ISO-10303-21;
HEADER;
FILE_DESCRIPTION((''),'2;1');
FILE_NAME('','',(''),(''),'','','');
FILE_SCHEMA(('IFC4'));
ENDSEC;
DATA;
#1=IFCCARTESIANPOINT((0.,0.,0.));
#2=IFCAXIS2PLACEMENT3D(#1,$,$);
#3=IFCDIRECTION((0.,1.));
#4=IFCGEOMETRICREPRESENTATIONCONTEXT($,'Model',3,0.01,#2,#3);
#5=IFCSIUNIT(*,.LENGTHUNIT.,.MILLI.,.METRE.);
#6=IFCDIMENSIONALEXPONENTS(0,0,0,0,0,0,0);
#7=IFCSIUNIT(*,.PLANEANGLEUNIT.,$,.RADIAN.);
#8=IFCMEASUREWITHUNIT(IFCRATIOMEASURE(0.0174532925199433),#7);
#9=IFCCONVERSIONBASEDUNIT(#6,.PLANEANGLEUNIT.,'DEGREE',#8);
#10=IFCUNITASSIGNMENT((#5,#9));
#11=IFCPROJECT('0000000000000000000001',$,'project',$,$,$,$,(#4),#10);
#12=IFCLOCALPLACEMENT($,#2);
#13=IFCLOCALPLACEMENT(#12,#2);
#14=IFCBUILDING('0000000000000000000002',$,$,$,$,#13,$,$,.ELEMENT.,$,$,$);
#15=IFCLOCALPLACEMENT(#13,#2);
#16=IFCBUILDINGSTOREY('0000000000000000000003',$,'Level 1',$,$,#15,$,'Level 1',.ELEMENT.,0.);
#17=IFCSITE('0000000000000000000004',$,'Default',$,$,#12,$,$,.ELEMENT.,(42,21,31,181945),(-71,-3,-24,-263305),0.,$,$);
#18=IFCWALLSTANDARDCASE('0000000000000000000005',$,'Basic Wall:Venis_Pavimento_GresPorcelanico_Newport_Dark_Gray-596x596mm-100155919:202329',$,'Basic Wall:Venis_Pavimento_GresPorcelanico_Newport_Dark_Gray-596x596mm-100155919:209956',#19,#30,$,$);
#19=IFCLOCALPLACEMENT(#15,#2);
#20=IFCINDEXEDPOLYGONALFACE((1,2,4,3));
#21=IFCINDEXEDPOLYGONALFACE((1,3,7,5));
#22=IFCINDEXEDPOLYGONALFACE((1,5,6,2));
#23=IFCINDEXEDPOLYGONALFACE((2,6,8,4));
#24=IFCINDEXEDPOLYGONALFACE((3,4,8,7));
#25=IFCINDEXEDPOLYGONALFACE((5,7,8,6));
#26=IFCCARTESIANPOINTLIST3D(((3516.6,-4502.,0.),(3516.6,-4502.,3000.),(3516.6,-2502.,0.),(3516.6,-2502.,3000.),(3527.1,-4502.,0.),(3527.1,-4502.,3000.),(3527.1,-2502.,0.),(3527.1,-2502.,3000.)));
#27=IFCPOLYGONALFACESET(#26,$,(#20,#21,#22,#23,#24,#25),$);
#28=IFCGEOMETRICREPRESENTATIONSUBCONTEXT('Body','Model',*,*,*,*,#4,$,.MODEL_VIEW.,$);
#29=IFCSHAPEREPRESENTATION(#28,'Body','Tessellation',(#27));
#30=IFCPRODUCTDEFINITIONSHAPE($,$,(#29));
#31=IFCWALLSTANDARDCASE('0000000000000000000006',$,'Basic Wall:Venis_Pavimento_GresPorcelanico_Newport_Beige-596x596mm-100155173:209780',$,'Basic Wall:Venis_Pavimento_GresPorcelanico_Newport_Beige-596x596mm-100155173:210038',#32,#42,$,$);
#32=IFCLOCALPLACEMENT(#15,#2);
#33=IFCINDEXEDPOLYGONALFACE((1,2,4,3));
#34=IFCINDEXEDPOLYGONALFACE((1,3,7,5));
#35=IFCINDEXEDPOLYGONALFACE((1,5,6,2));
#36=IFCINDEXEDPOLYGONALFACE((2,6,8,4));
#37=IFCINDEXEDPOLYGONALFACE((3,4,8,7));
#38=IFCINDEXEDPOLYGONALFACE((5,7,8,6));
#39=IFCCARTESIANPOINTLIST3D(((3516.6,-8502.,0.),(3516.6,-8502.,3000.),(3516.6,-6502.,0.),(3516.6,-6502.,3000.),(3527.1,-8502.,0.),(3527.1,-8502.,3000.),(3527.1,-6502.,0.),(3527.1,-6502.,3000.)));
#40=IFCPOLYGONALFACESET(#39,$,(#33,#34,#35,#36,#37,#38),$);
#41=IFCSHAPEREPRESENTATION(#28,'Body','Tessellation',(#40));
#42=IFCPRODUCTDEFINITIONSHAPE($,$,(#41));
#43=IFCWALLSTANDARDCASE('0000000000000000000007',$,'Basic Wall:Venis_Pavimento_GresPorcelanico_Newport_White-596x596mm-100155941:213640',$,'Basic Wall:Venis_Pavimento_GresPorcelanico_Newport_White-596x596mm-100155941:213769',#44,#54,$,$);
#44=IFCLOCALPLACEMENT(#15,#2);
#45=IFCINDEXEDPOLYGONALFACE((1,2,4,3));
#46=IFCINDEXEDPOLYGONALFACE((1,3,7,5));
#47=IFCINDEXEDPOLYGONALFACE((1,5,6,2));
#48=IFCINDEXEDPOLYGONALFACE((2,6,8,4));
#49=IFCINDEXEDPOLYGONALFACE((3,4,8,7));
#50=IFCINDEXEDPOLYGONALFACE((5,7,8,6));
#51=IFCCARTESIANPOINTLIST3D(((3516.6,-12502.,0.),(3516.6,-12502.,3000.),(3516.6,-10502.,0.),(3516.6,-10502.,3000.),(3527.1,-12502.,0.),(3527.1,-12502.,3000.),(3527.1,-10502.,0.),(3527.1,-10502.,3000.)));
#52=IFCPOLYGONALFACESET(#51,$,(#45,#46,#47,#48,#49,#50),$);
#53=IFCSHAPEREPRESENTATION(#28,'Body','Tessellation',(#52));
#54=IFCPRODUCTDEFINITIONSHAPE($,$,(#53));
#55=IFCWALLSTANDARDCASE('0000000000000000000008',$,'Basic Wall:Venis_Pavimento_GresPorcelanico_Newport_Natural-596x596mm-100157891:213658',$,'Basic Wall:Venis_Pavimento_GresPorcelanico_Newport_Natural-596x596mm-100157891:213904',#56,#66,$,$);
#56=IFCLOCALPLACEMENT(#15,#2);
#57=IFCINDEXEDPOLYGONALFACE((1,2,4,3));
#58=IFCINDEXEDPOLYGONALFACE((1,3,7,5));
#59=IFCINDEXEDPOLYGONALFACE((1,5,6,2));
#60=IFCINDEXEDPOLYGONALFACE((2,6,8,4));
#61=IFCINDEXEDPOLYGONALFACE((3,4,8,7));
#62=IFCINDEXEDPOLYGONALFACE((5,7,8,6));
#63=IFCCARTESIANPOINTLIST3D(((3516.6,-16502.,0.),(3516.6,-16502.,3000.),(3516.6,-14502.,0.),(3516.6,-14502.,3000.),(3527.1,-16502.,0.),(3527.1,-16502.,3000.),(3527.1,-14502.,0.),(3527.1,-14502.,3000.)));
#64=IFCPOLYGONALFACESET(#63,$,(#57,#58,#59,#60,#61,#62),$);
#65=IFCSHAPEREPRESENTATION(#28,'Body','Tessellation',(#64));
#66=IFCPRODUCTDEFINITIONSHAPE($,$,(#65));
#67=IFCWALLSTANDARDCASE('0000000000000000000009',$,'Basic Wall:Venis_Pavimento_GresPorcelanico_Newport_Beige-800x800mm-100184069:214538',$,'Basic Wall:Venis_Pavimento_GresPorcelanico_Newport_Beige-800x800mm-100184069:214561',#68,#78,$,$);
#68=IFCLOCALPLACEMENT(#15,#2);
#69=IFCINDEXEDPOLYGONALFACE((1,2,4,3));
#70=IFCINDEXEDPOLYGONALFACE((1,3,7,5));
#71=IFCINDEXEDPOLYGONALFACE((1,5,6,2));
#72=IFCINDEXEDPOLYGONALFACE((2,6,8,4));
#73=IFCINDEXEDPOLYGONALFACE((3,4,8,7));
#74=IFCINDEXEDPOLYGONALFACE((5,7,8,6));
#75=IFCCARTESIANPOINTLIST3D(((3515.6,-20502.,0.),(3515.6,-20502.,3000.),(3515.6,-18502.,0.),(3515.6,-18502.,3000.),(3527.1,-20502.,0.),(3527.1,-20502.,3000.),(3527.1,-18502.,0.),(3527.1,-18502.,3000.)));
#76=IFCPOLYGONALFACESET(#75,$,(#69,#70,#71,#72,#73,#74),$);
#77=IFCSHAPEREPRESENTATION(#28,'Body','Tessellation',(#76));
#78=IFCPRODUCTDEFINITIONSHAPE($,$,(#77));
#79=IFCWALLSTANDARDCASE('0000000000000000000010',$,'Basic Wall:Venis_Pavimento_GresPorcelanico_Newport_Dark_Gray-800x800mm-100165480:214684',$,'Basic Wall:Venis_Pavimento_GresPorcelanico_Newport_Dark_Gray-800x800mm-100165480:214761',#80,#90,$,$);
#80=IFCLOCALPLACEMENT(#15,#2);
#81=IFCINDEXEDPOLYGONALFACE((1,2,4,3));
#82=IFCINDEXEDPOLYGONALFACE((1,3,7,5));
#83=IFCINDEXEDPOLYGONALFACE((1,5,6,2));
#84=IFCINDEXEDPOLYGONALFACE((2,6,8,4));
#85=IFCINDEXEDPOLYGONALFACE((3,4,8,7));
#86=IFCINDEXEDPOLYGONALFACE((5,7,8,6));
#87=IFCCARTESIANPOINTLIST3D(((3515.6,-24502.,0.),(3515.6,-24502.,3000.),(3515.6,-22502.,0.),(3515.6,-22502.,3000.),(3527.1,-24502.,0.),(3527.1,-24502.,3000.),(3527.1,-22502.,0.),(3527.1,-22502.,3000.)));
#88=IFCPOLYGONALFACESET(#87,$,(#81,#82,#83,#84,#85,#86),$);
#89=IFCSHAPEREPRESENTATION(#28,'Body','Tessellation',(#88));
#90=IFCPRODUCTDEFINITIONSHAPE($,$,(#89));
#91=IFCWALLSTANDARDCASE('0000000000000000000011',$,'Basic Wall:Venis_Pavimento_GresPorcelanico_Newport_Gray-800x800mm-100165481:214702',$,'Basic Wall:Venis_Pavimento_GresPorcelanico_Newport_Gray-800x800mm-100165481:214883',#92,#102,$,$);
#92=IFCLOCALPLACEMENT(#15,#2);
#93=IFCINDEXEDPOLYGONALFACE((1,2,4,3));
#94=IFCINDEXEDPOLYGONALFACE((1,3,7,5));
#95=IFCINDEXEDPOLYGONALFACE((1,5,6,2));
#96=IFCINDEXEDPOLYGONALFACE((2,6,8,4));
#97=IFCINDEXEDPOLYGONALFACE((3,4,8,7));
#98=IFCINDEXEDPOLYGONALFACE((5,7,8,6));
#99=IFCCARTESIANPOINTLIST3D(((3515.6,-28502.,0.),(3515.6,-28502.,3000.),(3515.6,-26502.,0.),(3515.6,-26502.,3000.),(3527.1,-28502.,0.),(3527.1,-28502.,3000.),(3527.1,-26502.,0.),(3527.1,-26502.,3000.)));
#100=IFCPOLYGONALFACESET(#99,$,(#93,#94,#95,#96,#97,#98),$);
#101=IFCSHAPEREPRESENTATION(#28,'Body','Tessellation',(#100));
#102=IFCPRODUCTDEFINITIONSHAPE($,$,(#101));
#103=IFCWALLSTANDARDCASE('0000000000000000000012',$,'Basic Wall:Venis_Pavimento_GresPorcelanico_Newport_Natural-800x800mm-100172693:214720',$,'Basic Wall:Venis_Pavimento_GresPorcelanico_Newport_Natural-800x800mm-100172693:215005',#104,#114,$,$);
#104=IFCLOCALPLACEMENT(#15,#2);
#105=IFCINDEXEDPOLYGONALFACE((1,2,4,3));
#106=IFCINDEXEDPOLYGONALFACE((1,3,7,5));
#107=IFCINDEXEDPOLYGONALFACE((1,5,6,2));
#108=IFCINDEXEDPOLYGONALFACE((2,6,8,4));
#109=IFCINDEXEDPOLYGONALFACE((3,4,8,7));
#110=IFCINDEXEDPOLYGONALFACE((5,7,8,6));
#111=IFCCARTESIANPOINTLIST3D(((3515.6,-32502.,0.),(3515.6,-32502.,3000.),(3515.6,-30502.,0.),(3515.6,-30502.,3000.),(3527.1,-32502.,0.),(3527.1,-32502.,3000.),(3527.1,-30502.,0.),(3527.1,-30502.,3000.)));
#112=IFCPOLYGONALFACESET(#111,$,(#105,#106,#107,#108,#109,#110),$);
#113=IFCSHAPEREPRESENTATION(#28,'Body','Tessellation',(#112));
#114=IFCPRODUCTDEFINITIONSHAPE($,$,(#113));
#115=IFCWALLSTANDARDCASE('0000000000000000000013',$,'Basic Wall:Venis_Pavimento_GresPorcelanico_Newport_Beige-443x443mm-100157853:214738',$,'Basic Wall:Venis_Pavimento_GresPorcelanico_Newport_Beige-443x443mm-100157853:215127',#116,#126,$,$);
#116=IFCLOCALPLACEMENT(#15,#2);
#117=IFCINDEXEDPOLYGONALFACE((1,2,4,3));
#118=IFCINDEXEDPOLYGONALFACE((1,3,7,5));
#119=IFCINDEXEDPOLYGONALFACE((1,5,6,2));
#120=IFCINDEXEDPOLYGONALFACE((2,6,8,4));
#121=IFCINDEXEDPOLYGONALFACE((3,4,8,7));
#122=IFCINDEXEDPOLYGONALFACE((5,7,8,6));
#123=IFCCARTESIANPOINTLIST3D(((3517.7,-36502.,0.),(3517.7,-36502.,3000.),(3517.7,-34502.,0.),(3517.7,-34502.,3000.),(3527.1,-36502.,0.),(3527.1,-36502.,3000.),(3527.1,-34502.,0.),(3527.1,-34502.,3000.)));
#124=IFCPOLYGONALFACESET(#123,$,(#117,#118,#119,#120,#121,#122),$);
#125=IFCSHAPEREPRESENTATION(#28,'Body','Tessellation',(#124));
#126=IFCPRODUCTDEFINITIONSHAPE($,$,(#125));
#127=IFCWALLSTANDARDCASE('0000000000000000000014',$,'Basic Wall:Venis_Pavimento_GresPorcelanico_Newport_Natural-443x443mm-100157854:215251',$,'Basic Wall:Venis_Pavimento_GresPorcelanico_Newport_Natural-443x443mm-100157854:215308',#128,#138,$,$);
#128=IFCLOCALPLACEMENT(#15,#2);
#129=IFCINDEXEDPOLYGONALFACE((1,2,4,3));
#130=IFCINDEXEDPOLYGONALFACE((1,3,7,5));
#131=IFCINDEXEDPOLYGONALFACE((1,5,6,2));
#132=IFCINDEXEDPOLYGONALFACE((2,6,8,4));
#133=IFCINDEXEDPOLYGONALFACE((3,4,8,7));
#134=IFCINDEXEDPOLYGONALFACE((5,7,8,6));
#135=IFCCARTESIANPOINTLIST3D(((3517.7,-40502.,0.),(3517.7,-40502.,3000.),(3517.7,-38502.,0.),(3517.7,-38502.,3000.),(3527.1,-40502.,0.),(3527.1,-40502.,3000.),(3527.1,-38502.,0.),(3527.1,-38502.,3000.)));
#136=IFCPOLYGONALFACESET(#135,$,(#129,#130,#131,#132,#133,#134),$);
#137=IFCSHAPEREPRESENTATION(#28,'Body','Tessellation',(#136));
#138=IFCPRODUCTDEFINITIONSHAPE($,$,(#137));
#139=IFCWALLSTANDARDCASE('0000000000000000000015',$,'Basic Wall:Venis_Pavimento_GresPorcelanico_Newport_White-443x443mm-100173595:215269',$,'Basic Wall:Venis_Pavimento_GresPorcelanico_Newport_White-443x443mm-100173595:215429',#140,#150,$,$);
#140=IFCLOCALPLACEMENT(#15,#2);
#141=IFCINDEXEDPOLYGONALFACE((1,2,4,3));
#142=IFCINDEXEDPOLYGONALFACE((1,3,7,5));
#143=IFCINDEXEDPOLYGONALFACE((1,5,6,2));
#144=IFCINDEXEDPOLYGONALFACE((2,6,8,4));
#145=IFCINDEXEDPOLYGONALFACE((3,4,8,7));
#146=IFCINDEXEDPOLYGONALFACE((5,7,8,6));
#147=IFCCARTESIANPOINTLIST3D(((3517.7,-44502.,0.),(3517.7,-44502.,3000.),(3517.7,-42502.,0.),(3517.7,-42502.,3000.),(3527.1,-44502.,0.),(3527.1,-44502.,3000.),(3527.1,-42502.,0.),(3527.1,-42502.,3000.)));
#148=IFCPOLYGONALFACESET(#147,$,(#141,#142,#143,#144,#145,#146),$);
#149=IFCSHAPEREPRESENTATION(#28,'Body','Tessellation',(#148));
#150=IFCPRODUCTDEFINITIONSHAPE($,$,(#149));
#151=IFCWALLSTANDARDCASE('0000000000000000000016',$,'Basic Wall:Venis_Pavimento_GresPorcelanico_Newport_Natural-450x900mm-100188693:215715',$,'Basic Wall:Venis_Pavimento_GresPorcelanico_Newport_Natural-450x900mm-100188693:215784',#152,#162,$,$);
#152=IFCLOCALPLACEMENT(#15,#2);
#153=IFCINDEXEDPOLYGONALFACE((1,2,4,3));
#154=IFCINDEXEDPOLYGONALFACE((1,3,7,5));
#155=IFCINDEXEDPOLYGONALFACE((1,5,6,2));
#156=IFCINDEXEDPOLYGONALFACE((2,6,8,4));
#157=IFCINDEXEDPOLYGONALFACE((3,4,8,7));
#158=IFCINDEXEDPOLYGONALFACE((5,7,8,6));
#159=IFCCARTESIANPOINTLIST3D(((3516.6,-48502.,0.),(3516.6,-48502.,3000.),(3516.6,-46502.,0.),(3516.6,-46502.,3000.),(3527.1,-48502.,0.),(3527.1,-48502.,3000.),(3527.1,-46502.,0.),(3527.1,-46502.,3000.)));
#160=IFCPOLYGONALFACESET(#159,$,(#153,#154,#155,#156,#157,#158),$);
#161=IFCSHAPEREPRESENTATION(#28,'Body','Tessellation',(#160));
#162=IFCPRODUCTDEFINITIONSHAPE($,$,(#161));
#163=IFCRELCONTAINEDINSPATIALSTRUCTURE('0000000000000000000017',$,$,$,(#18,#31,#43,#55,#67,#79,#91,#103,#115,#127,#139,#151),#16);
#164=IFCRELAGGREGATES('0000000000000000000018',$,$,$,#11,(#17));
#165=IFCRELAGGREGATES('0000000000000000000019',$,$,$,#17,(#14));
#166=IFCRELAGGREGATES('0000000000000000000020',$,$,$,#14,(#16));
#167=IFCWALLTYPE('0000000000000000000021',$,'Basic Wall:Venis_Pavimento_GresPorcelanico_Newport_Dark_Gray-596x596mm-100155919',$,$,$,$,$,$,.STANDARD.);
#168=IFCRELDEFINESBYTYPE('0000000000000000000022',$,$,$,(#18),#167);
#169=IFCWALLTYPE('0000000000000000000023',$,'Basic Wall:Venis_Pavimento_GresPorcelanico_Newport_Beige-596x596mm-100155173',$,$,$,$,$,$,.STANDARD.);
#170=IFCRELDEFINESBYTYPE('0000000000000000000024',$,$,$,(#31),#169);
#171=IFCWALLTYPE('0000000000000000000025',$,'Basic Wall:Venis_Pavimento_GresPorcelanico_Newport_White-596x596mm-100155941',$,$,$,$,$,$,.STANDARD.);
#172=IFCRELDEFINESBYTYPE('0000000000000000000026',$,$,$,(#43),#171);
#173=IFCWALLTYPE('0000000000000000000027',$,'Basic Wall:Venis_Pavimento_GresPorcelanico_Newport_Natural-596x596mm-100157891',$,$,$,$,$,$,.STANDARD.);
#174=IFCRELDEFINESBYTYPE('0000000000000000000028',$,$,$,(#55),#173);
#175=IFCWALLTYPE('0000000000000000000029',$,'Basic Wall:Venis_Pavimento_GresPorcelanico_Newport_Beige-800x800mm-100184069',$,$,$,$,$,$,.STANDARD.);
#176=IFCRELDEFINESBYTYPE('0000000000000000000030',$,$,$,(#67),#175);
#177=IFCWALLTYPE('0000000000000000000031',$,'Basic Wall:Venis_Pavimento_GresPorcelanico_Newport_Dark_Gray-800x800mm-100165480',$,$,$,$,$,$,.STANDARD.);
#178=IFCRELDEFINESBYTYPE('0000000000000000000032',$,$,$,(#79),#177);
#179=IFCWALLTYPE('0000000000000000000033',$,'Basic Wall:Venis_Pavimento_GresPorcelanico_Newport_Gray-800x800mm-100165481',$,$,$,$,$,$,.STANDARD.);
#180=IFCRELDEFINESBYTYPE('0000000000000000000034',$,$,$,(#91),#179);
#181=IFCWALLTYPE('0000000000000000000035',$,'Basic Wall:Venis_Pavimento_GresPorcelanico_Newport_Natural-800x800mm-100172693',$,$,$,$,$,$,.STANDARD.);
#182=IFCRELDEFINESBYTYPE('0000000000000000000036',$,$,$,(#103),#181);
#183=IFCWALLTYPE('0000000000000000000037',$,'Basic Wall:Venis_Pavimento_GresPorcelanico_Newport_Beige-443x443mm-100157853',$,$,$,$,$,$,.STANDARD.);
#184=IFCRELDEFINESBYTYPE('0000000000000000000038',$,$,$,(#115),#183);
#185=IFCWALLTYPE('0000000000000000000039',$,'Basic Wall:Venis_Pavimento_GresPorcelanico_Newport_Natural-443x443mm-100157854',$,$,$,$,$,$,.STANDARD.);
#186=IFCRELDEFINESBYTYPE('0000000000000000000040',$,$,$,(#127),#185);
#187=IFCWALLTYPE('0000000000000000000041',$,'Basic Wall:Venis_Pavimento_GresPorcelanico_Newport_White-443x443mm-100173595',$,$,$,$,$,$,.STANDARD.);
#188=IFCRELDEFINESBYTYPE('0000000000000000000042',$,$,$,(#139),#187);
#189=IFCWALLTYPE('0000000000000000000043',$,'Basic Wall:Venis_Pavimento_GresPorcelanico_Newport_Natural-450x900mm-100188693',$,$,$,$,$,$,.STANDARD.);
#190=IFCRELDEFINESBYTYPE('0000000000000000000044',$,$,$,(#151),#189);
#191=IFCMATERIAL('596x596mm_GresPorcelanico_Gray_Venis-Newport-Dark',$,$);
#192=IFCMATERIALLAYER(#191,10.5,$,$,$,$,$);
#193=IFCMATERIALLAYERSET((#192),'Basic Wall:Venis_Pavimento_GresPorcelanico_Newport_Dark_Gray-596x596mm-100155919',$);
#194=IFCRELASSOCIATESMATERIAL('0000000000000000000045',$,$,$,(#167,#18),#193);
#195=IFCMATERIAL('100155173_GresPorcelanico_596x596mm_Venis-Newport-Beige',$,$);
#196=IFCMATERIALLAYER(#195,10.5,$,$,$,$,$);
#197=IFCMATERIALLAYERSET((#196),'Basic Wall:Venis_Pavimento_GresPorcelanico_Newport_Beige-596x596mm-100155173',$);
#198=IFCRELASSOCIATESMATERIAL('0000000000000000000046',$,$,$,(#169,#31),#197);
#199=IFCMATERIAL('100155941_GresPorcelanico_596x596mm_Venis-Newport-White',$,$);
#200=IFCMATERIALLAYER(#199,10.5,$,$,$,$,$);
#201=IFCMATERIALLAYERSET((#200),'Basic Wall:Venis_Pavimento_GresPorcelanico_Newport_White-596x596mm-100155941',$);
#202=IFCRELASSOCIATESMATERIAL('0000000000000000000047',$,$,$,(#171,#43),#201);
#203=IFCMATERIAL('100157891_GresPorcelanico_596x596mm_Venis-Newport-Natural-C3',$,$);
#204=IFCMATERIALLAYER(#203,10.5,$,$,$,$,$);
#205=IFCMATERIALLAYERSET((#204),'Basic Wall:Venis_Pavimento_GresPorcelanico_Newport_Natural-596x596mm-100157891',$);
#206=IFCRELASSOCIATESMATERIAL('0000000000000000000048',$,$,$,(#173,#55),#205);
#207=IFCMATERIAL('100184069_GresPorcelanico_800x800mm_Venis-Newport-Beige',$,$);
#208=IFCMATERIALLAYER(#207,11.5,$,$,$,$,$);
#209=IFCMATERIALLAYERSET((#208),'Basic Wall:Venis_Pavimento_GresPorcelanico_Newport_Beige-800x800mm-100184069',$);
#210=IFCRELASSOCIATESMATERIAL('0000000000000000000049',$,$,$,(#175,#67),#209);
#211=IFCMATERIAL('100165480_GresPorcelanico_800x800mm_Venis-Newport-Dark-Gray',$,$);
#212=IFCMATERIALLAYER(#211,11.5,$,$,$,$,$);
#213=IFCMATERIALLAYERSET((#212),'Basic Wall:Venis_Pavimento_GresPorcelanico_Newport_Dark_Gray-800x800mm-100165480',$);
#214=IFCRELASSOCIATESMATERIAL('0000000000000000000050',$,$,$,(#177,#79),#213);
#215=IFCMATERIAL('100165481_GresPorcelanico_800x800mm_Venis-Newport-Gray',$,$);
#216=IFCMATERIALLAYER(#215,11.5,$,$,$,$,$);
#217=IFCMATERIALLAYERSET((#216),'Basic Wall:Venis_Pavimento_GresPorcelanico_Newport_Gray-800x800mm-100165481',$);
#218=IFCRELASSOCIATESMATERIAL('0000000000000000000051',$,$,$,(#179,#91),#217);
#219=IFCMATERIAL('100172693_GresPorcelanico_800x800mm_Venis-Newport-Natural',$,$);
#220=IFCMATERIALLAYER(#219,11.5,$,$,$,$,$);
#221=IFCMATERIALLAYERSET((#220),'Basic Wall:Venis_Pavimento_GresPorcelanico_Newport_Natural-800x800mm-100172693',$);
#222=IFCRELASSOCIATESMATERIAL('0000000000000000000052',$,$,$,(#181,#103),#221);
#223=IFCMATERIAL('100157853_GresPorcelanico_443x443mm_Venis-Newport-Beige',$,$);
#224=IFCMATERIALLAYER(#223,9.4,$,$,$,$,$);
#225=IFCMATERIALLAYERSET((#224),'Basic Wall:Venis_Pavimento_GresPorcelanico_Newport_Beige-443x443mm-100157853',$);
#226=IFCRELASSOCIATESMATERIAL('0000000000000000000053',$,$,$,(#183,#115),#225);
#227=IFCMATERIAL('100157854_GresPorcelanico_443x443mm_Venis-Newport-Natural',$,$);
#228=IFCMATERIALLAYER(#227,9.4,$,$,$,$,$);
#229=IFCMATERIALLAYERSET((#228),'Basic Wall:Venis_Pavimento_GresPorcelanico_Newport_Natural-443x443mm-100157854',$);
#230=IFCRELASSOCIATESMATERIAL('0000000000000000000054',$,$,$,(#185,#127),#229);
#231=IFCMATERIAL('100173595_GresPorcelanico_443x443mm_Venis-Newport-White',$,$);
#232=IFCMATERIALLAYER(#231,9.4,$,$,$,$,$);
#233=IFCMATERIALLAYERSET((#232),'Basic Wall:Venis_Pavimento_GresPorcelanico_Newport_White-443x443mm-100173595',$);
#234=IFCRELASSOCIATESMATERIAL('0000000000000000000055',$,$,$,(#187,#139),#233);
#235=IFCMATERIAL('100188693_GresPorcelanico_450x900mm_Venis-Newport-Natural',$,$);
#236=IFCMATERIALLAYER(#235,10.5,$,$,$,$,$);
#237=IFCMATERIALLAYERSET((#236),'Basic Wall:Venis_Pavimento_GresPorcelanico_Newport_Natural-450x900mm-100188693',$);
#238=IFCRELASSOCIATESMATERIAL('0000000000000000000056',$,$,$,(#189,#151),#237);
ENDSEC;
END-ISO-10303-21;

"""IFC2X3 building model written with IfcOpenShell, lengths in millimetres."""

from ifc_helpers import new_model, entity, si_unit, converted_unit, direction, frame, frame_2d, origin, place, context, subcontext, project, spatial, rectangle, extrude, material, layer, layer_set, layer_usage, type_object, element, save


model = new_model("IFC2X3")

# Units and contexts
model_context = context("Model", 3, precision=0.01, world=origin(), true_north=direction((0.0, 1.0)))
body_context = subcontext(model_context, "Body", "Model", "MODEL_VIEW")
ifc_project = project(units=[si_unit("LENGTHUNIT", "METRE", prefix="MILLI"), converted_unit("PLANEANGLEUNIT", "DEGREE", entity("IfcRatioMeasure", 0.0174532925199433), si_unit("PLANEANGLEUNIT", "RADIAN"), dimensions=[0, 0, 0, 0, 0, 0, 0])], contexts=[model_context])

# Site, building, storey
site_placement = place(None, origin())
site = spatial("IfcSite", under=ifc_project, at=site_placement, Name="Default", CompositionType="ELEMENT", RefLatitude=(42, 21, 31, 181945), RefLongitude=(-71, -3, -24, -263305), RefElevation=0.0)
building_placement = place(site_placement, origin())
building = spatial("IfcBuilding", under=site, at=building_placement, CompositionType="ELEMENT")
storey_placement = place(building_placement, origin())
storey = spatial("IfcBuildingStorey", under=building, at=storey_placement, Name="Level 1", LongName="Level 1", CompositionType="ELEMENT", Elevation=0.0)

# Walls
ifc_material_1 = material(Name="596x596mm_GresPorcelanico_Gray_Venis-Newport-Dark")
ifc_layer_1 = layer(ifc_material_1, 10.5)
ifc_layer_set_1 = layer_set([ifc_layer_1], Name="Basic Wall:Venis_Pavimento_GresPorcelanico_Newport_Dark_Gray-596x596mm-100155919")
ifc_layer_usage_1 = layer_usage(ifc_layer_set_1, "AXIS2", "POSITIVE", -5.2)
wall_type_1 = type_object("IfcWallType", Name="Basic Wall:Venis_Pavimento_GresPorcelanico_Newport_Dark_Gray-596x596mm-100155919", PredefinedType="STANDARD", material=ifc_layer_set_1)
wall_1_placement = place(storey_placement, frame((3521.8, -2502.0, 0.0), z_axis=(0.0, 0.0, 1.0), x_axis=(0.0, -1.0, 0.0)))
element("IfcWallStandardCase", 1, at=wall_1_placement, inside=storey, type_object=wall_type_1, material=ifc_layer_usage_1, Name="Basic Wall:Venis_Pavimento_GresPorcelanico_Newport_Dark_Gray-596x596mm-100155919:202329", ObjectType="Basic Wall:Venis_Pavimento_GresPorcelanico_Newport_Dark_Gray-596x596mm-100155919:209956", context=body_context, shape_type="SweptSolid", body=[
    extrude(rectangle(XDim=2000.0, YDim=10.5, at=frame_2d((1000.0, 0.0), x_axis=(-1.0, 0.0))), origin(), (0.0, 0.0, 1.0), 3000.0),
])
ifc_material_2 = material(Name="100155173_GresPorcelanico_596x596mm_Venis-Newport-Beige")
ifc_layer_2 = layer(ifc_material_2, 10.5)
ifc_layer_set_2 = layer_set([ifc_layer_2], Name="Basic Wall:Venis_Pavimento_GresPorcelanico_Newport_Beige-596x596mm-100155173")
ifc_layer_usage_2 = layer_usage(ifc_layer_set_2, "AXIS2", "POSITIVE", -5.2)
wall_type_2 = type_object("IfcWallType", Name="Basic Wall:Venis_Pavimento_GresPorcelanico_Newport_Beige-596x596mm-100155173", PredefinedType="STANDARD", material=ifc_layer_set_2)
wall_2_placement = place(storey_placement, frame((3521.8, -6502.0, 0.0), z_axis=(0.0, 0.0, 1.0), x_axis=(0.0, -1.0, 0.0)))
element("IfcWallStandardCase", 2, at=wall_2_placement, inside=storey, type_object=wall_type_2, material=ifc_layer_usage_2, Name="Basic Wall:Venis_Pavimento_GresPorcelanico_Newport_Beige-596x596mm-100155173:209780", ObjectType="Basic Wall:Venis_Pavimento_GresPorcelanico_Newport_Beige-596x596mm-100155173:210038", context=body_context, shape_type="SweptSolid", body=[
    extrude(rectangle(XDim=2000.0, YDim=10.5, at=frame_2d((1000.0, 0.0), x_axis=(-1.0, 0.0))), origin(), (0.0, 0.0, 1.0), 3000.0),
])
ifc_material_3 = material(Name="100155941_GresPorcelanico_596x596mm_Venis-Newport-White")
ifc_layer_3 = layer(ifc_material_3, 10.5)
ifc_layer_set_3 = layer_set([ifc_layer_3], Name="Basic Wall:Venis_Pavimento_GresPorcelanico_Newport_White-596x596mm-100155941")
ifc_layer_usage_3 = layer_usage(ifc_layer_set_3, "AXIS2", "POSITIVE", -5.2)
wall_type_3 = type_object("IfcWallType", Name="Basic Wall:Venis_Pavimento_GresPorcelanico_Newport_White-596x596mm-100155941", PredefinedType="STANDARD", material=ifc_layer_set_3)
wall_3_placement = place(storey_placement, frame((3521.8, -10502.0, 0.0), z_axis=(0.0, 0.0, 1.0), x_axis=(0.0, -1.0, 0.0)))
element("IfcWallStandardCase", 3, at=wall_3_placement, inside=storey, type_object=wall_type_3, material=ifc_layer_usage_3, Name="Basic Wall:Venis_Pavimento_GresPorcelanico_Newport_White-596x596mm-100155941:213640", ObjectType="Basic Wall:Venis_Pavimento_GresPorcelanico_Newport_White-596x596mm-100155941:213769", context=body_context, shape_type="SweptSolid", body=[
    extrude(rectangle(XDim=2000.0, YDim=10.5, at=frame_2d((1000.0, 0.0), x_axis=(-1.0, 0.0))), origin(), (0.0, 0.0, 1.0), 3000.0),
])
ifc_material_4 = material(Name="100157891_GresPorcelanico_596x596mm_Venis-Newport-Natural-C3")
ifc_layer_4 = layer(ifc_material_4, 10.5)
ifc_layer_set_4 = layer_set([ifc_layer_4], Name="Basic Wall:Venis_Pavimento_GresPorcelanico_Newport_Natural-596x596mm-100157891")
ifc_layer_usage_4 = layer_usage(ifc_layer_set_4, "AXIS2", "POSITIVE", -5.2)
wall_type_4 = type_object("IfcWallType", Name="Basic Wall:Venis_Pavimento_GresPorcelanico_Newport_Natural-596x596mm-100157891", PredefinedType="STANDARD", material=ifc_layer_set_4)
wall_4_placement = place(storey_placement, frame((3521.8, -14502.0, 0.0), z_axis=(0.0, 0.0, 1.0), x_axis=(0.0, -1.0, 0.0)))
element("IfcWallStandardCase", 4, at=wall_4_placement, inside=storey, type_object=wall_type_4, material=ifc_layer_usage_4, Name="Basic Wall:Venis_Pavimento_GresPorcelanico_Newport_Natural-596x596mm-100157891:213658", ObjectType="Basic Wall:Venis_Pavimento_GresPorcelanico_Newport_Natural-596x596mm-100157891:213904", context=body_context, shape_type="SweptSolid", body=[
    extrude(rectangle(XDim=2000.0, YDim=10.5, at=frame_2d((1000.0, 0.0), x_axis=(-1.0, 0.0))), origin(), (0.0, 0.0, 1.0), 3000.0),
])
ifc_material_5 = material(Name="100184069_GresPorcelanico_800x800mm_Venis-Newport-Beige")
ifc_layer_5 = layer(ifc_material_5, 11.5)
ifc_layer_set_5 = layer_set([ifc_layer_5], Name="Basic Wall:Venis_Pavimento_GresPorcelanico_Newport_Beige-800x800mm-100184069")
ifc_layer_usage_5 = layer_usage(ifc_layer_set_5, "AXIS2", "POSITIVE", -5.8)
wall_type_5 = type_object("IfcWallType", Name="Basic Wall:Venis_Pavimento_GresPorcelanico_Newport_Beige-800x800mm-100184069", PredefinedType="STANDARD", material=ifc_layer_set_5)
wall_5_placement = place(storey_placement, frame((3521.3, -18502.0, 0.0), z_axis=(0.0, 0.0, 1.0), x_axis=(0.0, -1.0, 0.0)))
element("IfcWallStandardCase", 5, at=wall_5_placement, inside=storey, type_object=wall_type_5, material=ifc_layer_usage_5, Name="Basic Wall:Venis_Pavimento_GresPorcelanico_Newport_Beige-800x800mm-100184069:214538", ObjectType="Basic Wall:Venis_Pavimento_GresPorcelanico_Newport_Beige-800x800mm-100184069:214561", context=body_context, shape_type="SweptSolid", body=[
    extrude(rectangle(XDim=2000.0, YDim=11.5, at=frame_2d((1000.0, 0.0), x_axis=(-1.0, 0.0))), origin(), (0.0, 0.0, 1.0), 3000.0),
])
ifc_material_6 = material(Name="100165480_GresPorcelanico_800x800mm_Venis-Newport-Dark-Gray")
ifc_layer_6 = layer(ifc_material_6, 11.5)
ifc_layer_set_6 = layer_set([ifc_layer_6], Name="Basic Wall:Venis_Pavimento_GresPorcelanico_Newport_Dark_Gray-800x800mm-100165480")
ifc_layer_usage_6 = layer_usage(ifc_layer_set_6, "AXIS2", "POSITIVE", -5.8)
wall_type_6 = type_object("IfcWallType", Name="Basic Wall:Venis_Pavimento_GresPorcelanico_Newport_Dark_Gray-800x800mm-100165480", PredefinedType="STANDARD", material=ifc_layer_set_6)
wall_6_placement = place(storey_placement, frame((3521.3, -22502.0, 0.0), z_axis=(0.0, 0.0, 1.0), x_axis=(0.0, -1.0, 0.0)))
element("IfcWallStandardCase", 6, at=wall_6_placement, inside=storey, type_object=wall_type_6, material=ifc_layer_usage_6, Name="Basic Wall:Venis_Pavimento_GresPorcelanico_Newport_Dark_Gray-800x800mm-100165480:214684", ObjectType="Basic Wall:Venis_Pavimento_GresPorcelanico_Newport_Dark_Gray-800x800mm-100165480:214761", context=body_context, shape_type="SweptSolid", body=[
    extrude(rectangle(XDim=2000.0, YDim=11.5, at=frame_2d((1000.0, 0.0), x_axis=(-1.0, 0.0))), origin(), (0.0, 0.0, 1.0), 3000.0),
])
ifc_material_7 = material(Name="100165481_GresPorcelanico_800x800mm_Venis-Newport-Gray")
ifc_layer_7 = layer(ifc_material_7, 11.5)
ifc_layer_set_7 = layer_set([ifc_layer_7], Name="Basic Wall:Venis_Pavimento_GresPorcelanico_Newport_Gray-800x800mm-100165481")
ifc_layer_usage_7 = layer_usage(ifc_layer_set_7, "AXIS2", "POSITIVE", -5.8)
wall_type_7 = type_object("IfcWallType", Name="Basic Wall:Venis_Pavimento_GresPorcelanico_Newport_Gray-800x800mm-100165481", PredefinedType="STANDARD", material=ifc_layer_set_7)
wall_7_placement = place(storey_placement, frame((3521.3, -26502.0, 0.0), z_axis=(0.0, 0.0, 1.0), x_axis=(0.0, -1.0, 0.0)))
element("IfcWallStandardCase", 7, at=wall_7_placement, inside=storey, type_object=wall_type_7, material=ifc_layer_usage_7, Name="Basic Wall:Venis_Pavimento_GresPorcelanico_Newport_Gray-800x800mm-100165481:214702", ObjectType="Basic Wall:Venis_Pavimento_GresPorcelanico_Newport_Gray-800x800mm-100165481:214883", context=body_context, shape_type="SweptSolid", body=[
    extrude(rectangle(XDim=2000.0, YDim=11.5, at=frame_2d((1000.0, 0.0), x_axis=(-1.0, 0.0))), origin(), (0.0, 0.0, 1.0), 3000.0),
])
ifc_material_8 = material(Name="100172693_GresPorcelanico_800x800mm_Venis-Newport-Natural")
ifc_layer_8 = layer(ifc_material_8, 11.5)
ifc_layer_set_8 = layer_set([ifc_layer_8], Name="Basic Wall:Venis_Pavimento_GresPorcelanico_Newport_Natural-800x800mm-100172693")
ifc_layer_usage_8 = layer_usage(ifc_layer_set_8, "AXIS2", "POSITIVE", -5.8)
wall_type_8 = type_object("IfcWallType", Name="Basic Wall:Venis_Pavimento_GresPorcelanico_Newport_Natural-800x800mm-100172693", PredefinedType="STANDARD", material=ifc_layer_set_8)
wall_8_placement = place(storey_placement, frame((3521.3, -30502.0, 0.0), z_axis=(0.0, 0.0, 1.0), x_axis=(0.0, -1.0, 0.0)))
element("IfcWallStandardCase", 8, at=wall_8_placement, inside=storey, type_object=wall_type_8, material=ifc_layer_usage_8, Name="Basic Wall:Venis_Pavimento_GresPorcelanico_Newport_Natural-800x800mm-100172693:214720", ObjectType="Basic Wall:Venis_Pavimento_GresPorcelanico_Newport_Natural-800x800mm-100172693:215005", context=body_context, shape_type="SweptSolid", body=[
    extrude(rectangle(XDim=2000.0, YDim=11.5, at=frame_2d((1000.0, 0.0), x_axis=(-1.0, 0.0))), origin(), (0.0, 0.0, 1.0), 3000.0),
])
ifc_material_9 = material(Name="100157853_GresPorcelanico_443x443mm_Venis-Newport-Beige")
ifc_layer_9 = layer(ifc_material_9, 9.4)
ifc_layer_set_9 = layer_set([ifc_layer_9], Name="Basic Wall:Venis_Pavimento_GresPorcelanico_Newport_Beige-443x443mm-100157853")
ifc_layer_usage_9 = layer_usage(ifc_layer_set_9, "AXIS2", "POSITIVE", -4.7)
wall_type_9 = type_object("IfcWallType", Name="Basic Wall:Venis_Pavimento_GresPorcelanico_Newport_Beige-443x443mm-100157853", PredefinedType="STANDARD", material=ifc_layer_set_9)
wall_9_placement = place(storey_placement, frame((3522.4, -34502.0, 0.0), z_axis=(0.0, 0.0, 1.0), x_axis=(0.0, -1.0, 0.0)))
element("IfcWallStandardCase", 9, at=wall_9_placement, inside=storey, type_object=wall_type_9, material=ifc_layer_usage_9, Name="Basic Wall:Venis_Pavimento_GresPorcelanico_Newport_Beige-443x443mm-100157853:214738", ObjectType="Basic Wall:Venis_Pavimento_GresPorcelanico_Newport_Beige-443x443mm-100157853:215127", context=body_context, shape_type="SweptSolid", body=[
    extrude(rectangle(XDim=2000.0, YDim=9.4, at=frame_2d((1000.0, 0.0), x_axis=(-1.0, 0.0))), origin(), (0.0, 0.0, 1.0), 3000.0),
])
ifc_material_10 = material(Name="100157854_GresPorcelanico_443x443mm_Venis-Newport-Natural")
ifc_layer_10 = layer(ifc_material_10, 9.4)
ifc_layer_set_10 = layer_set([ifc_layer_10], Name="Basic Wall:Venis_Pavimento_GresPorcelanico_Newport_Natural-443x443mm-100157854")
ifc_layer_usage_10 = layer_usage(ifc_layer_set_10, "AXIS2", "POSITIVE", -4.7)
wall_type_10 = type_object("IfcWallType", Name="Basic Wall:Venis_Pavimento_GresPorcelanico_Newport_Natural-443x443mm-100157854", PredefinedType="STANDARD", material=ifc_layer_set_10)
wall_10_placement = place(storey_placement, frame((3522.4, -38502.0, 0.0), z_axis=(0.0, 0.0, 1.0), x_axis=(0.0, -1.0, 0.0)))
element("IfcWallStandardCase", 10, at=wall_10_placement, inside=storey, type_object=wall_type_10, material=ifc_layer_usage_10, Name="Basic Wall:Venis_Pavimento_GresPorcelanico_Newport_Natural-443x443mm-100157854:215251", ObjectType="Basic Wall:Venis_Pavimento_GresPorcelanico_Newport_Natural-443x443mm-100157854:215308", context=body_context, shape_type="SweptSolid", body=[
    extrude(rectangle(XDim=2000.0, YDim=9.4, at=frame_2d((1000.0, 0.0), x_axis=(-1.0, 0.0))), origin(), (0.0, 0.0, 1.0), 3000.0),
])
ifc_material_11 = material(Name="100173595_GresPorcelanico_443x443mm_Venis-Newport-White")
ifc_layer_11 = layer(ifc_material_11, 9.4)
ifc_layer_set_11 = layer_set([ifc_layer_11], Name="Basic Wall:Venis_Pavimento_GresPorcelanico_Newport_White-443x443mm-100173595")
ifc_layer_usage_11 = layer_usage(ifc_layer_set_11, "AXIS2", "POSITIVE", -4.7)
wall_type_11 = type_object("IfcWallType", Name="Basic Wall:Venis_Pavimento_GresPorcelanico_Newport_White-443x443mm-100173595", PredefinedType="STANDARD", material=ifc_layer_set_11)
wall_11_placement = place(storey_placement, frame((3522.4, -42502.0, 0.0), z_axis=(0.0, 0.0, 1.0), x_axis=(0.0, -1.0, 0.0)))
element("IfcWallStandardCase", 11, at=wall_11_placement, inside=storey, type_object=wall_type_11, material=ifc_layer_usage_11, Name="Basic Wall:Venis_Pavimento_GresPorcelanico_Newport_White-443x443mm-100173595:215269", ObjectType="Basic Wall:Venis_Pavimento_GresPorcelanico_Newport_White-443x443mm-100173595:215429", context=body_context, shape_type="SweptSolid", body=[
    extrude(rectangle(XDim=2000.0, YDim=9.4, at=frame_2d((1000.0, 0.0), x_axis=(-1.0, 0.0))), origin(), (0.0, 0.0, 1.0), 3000.0),
])
ifc_material_12 = material(Name="100188693_GresPorcelanico_450x900mm_Venis-Newport-Natural")
ifc_layer_12 = layer(ifc_material_12, 10.5)
ifc_layer_set_12 = layer_set([ifc_layer_12], Name="Basic Wall:Venis_Pavimento_GresPorcelanico_Newport_Natural-450x900mm-100188693")
ifc_layer_usage_12 = layer_usage(ifc_layer_set_12, "AXIS2", "POSITIVE", -5.2)
wall_type_12 = type_object("IfcWallType", Name="Basic Wall:Venis_Pavimento_GresPorcelanico_Newport_Natural-450x900mm-100188693", PredefinedType="STANDARD", material=ifc_layer_set_12)
wall_12_placement = place(storey_placement, frame((3521.8, -46502.0, 0.0), z_axis=(0.0, 0.0, 1.0), x_axis=(0.0, -1.0, 0.0)))
element("IfcWallStandardCase", 12, at=wall_12_placement, inside=storey, type_object=wall_type_12, material=ifc_layer_usage_12, Name="Basic Wall:Venis_Pavimento_GresPorcelanico_Newport_Natural-450x900mm-100188693:215715", ObjectType="Basic Wall:Venis_Pavimento_GresPorcelanico_Newport_Natural-450x900mm-100188693:215784", context=body_context, shape_type="SweptSolid", body=[
    extrude(rectangle(XDim=2000.0, YDim=10.5, at=frame_2d((1000.0, 0.0), x_axis=(-1.0, 0.0))), origin(), (0.0, 0.0, 1.0), 3000.0),
])

save(model, "model.ifc")
